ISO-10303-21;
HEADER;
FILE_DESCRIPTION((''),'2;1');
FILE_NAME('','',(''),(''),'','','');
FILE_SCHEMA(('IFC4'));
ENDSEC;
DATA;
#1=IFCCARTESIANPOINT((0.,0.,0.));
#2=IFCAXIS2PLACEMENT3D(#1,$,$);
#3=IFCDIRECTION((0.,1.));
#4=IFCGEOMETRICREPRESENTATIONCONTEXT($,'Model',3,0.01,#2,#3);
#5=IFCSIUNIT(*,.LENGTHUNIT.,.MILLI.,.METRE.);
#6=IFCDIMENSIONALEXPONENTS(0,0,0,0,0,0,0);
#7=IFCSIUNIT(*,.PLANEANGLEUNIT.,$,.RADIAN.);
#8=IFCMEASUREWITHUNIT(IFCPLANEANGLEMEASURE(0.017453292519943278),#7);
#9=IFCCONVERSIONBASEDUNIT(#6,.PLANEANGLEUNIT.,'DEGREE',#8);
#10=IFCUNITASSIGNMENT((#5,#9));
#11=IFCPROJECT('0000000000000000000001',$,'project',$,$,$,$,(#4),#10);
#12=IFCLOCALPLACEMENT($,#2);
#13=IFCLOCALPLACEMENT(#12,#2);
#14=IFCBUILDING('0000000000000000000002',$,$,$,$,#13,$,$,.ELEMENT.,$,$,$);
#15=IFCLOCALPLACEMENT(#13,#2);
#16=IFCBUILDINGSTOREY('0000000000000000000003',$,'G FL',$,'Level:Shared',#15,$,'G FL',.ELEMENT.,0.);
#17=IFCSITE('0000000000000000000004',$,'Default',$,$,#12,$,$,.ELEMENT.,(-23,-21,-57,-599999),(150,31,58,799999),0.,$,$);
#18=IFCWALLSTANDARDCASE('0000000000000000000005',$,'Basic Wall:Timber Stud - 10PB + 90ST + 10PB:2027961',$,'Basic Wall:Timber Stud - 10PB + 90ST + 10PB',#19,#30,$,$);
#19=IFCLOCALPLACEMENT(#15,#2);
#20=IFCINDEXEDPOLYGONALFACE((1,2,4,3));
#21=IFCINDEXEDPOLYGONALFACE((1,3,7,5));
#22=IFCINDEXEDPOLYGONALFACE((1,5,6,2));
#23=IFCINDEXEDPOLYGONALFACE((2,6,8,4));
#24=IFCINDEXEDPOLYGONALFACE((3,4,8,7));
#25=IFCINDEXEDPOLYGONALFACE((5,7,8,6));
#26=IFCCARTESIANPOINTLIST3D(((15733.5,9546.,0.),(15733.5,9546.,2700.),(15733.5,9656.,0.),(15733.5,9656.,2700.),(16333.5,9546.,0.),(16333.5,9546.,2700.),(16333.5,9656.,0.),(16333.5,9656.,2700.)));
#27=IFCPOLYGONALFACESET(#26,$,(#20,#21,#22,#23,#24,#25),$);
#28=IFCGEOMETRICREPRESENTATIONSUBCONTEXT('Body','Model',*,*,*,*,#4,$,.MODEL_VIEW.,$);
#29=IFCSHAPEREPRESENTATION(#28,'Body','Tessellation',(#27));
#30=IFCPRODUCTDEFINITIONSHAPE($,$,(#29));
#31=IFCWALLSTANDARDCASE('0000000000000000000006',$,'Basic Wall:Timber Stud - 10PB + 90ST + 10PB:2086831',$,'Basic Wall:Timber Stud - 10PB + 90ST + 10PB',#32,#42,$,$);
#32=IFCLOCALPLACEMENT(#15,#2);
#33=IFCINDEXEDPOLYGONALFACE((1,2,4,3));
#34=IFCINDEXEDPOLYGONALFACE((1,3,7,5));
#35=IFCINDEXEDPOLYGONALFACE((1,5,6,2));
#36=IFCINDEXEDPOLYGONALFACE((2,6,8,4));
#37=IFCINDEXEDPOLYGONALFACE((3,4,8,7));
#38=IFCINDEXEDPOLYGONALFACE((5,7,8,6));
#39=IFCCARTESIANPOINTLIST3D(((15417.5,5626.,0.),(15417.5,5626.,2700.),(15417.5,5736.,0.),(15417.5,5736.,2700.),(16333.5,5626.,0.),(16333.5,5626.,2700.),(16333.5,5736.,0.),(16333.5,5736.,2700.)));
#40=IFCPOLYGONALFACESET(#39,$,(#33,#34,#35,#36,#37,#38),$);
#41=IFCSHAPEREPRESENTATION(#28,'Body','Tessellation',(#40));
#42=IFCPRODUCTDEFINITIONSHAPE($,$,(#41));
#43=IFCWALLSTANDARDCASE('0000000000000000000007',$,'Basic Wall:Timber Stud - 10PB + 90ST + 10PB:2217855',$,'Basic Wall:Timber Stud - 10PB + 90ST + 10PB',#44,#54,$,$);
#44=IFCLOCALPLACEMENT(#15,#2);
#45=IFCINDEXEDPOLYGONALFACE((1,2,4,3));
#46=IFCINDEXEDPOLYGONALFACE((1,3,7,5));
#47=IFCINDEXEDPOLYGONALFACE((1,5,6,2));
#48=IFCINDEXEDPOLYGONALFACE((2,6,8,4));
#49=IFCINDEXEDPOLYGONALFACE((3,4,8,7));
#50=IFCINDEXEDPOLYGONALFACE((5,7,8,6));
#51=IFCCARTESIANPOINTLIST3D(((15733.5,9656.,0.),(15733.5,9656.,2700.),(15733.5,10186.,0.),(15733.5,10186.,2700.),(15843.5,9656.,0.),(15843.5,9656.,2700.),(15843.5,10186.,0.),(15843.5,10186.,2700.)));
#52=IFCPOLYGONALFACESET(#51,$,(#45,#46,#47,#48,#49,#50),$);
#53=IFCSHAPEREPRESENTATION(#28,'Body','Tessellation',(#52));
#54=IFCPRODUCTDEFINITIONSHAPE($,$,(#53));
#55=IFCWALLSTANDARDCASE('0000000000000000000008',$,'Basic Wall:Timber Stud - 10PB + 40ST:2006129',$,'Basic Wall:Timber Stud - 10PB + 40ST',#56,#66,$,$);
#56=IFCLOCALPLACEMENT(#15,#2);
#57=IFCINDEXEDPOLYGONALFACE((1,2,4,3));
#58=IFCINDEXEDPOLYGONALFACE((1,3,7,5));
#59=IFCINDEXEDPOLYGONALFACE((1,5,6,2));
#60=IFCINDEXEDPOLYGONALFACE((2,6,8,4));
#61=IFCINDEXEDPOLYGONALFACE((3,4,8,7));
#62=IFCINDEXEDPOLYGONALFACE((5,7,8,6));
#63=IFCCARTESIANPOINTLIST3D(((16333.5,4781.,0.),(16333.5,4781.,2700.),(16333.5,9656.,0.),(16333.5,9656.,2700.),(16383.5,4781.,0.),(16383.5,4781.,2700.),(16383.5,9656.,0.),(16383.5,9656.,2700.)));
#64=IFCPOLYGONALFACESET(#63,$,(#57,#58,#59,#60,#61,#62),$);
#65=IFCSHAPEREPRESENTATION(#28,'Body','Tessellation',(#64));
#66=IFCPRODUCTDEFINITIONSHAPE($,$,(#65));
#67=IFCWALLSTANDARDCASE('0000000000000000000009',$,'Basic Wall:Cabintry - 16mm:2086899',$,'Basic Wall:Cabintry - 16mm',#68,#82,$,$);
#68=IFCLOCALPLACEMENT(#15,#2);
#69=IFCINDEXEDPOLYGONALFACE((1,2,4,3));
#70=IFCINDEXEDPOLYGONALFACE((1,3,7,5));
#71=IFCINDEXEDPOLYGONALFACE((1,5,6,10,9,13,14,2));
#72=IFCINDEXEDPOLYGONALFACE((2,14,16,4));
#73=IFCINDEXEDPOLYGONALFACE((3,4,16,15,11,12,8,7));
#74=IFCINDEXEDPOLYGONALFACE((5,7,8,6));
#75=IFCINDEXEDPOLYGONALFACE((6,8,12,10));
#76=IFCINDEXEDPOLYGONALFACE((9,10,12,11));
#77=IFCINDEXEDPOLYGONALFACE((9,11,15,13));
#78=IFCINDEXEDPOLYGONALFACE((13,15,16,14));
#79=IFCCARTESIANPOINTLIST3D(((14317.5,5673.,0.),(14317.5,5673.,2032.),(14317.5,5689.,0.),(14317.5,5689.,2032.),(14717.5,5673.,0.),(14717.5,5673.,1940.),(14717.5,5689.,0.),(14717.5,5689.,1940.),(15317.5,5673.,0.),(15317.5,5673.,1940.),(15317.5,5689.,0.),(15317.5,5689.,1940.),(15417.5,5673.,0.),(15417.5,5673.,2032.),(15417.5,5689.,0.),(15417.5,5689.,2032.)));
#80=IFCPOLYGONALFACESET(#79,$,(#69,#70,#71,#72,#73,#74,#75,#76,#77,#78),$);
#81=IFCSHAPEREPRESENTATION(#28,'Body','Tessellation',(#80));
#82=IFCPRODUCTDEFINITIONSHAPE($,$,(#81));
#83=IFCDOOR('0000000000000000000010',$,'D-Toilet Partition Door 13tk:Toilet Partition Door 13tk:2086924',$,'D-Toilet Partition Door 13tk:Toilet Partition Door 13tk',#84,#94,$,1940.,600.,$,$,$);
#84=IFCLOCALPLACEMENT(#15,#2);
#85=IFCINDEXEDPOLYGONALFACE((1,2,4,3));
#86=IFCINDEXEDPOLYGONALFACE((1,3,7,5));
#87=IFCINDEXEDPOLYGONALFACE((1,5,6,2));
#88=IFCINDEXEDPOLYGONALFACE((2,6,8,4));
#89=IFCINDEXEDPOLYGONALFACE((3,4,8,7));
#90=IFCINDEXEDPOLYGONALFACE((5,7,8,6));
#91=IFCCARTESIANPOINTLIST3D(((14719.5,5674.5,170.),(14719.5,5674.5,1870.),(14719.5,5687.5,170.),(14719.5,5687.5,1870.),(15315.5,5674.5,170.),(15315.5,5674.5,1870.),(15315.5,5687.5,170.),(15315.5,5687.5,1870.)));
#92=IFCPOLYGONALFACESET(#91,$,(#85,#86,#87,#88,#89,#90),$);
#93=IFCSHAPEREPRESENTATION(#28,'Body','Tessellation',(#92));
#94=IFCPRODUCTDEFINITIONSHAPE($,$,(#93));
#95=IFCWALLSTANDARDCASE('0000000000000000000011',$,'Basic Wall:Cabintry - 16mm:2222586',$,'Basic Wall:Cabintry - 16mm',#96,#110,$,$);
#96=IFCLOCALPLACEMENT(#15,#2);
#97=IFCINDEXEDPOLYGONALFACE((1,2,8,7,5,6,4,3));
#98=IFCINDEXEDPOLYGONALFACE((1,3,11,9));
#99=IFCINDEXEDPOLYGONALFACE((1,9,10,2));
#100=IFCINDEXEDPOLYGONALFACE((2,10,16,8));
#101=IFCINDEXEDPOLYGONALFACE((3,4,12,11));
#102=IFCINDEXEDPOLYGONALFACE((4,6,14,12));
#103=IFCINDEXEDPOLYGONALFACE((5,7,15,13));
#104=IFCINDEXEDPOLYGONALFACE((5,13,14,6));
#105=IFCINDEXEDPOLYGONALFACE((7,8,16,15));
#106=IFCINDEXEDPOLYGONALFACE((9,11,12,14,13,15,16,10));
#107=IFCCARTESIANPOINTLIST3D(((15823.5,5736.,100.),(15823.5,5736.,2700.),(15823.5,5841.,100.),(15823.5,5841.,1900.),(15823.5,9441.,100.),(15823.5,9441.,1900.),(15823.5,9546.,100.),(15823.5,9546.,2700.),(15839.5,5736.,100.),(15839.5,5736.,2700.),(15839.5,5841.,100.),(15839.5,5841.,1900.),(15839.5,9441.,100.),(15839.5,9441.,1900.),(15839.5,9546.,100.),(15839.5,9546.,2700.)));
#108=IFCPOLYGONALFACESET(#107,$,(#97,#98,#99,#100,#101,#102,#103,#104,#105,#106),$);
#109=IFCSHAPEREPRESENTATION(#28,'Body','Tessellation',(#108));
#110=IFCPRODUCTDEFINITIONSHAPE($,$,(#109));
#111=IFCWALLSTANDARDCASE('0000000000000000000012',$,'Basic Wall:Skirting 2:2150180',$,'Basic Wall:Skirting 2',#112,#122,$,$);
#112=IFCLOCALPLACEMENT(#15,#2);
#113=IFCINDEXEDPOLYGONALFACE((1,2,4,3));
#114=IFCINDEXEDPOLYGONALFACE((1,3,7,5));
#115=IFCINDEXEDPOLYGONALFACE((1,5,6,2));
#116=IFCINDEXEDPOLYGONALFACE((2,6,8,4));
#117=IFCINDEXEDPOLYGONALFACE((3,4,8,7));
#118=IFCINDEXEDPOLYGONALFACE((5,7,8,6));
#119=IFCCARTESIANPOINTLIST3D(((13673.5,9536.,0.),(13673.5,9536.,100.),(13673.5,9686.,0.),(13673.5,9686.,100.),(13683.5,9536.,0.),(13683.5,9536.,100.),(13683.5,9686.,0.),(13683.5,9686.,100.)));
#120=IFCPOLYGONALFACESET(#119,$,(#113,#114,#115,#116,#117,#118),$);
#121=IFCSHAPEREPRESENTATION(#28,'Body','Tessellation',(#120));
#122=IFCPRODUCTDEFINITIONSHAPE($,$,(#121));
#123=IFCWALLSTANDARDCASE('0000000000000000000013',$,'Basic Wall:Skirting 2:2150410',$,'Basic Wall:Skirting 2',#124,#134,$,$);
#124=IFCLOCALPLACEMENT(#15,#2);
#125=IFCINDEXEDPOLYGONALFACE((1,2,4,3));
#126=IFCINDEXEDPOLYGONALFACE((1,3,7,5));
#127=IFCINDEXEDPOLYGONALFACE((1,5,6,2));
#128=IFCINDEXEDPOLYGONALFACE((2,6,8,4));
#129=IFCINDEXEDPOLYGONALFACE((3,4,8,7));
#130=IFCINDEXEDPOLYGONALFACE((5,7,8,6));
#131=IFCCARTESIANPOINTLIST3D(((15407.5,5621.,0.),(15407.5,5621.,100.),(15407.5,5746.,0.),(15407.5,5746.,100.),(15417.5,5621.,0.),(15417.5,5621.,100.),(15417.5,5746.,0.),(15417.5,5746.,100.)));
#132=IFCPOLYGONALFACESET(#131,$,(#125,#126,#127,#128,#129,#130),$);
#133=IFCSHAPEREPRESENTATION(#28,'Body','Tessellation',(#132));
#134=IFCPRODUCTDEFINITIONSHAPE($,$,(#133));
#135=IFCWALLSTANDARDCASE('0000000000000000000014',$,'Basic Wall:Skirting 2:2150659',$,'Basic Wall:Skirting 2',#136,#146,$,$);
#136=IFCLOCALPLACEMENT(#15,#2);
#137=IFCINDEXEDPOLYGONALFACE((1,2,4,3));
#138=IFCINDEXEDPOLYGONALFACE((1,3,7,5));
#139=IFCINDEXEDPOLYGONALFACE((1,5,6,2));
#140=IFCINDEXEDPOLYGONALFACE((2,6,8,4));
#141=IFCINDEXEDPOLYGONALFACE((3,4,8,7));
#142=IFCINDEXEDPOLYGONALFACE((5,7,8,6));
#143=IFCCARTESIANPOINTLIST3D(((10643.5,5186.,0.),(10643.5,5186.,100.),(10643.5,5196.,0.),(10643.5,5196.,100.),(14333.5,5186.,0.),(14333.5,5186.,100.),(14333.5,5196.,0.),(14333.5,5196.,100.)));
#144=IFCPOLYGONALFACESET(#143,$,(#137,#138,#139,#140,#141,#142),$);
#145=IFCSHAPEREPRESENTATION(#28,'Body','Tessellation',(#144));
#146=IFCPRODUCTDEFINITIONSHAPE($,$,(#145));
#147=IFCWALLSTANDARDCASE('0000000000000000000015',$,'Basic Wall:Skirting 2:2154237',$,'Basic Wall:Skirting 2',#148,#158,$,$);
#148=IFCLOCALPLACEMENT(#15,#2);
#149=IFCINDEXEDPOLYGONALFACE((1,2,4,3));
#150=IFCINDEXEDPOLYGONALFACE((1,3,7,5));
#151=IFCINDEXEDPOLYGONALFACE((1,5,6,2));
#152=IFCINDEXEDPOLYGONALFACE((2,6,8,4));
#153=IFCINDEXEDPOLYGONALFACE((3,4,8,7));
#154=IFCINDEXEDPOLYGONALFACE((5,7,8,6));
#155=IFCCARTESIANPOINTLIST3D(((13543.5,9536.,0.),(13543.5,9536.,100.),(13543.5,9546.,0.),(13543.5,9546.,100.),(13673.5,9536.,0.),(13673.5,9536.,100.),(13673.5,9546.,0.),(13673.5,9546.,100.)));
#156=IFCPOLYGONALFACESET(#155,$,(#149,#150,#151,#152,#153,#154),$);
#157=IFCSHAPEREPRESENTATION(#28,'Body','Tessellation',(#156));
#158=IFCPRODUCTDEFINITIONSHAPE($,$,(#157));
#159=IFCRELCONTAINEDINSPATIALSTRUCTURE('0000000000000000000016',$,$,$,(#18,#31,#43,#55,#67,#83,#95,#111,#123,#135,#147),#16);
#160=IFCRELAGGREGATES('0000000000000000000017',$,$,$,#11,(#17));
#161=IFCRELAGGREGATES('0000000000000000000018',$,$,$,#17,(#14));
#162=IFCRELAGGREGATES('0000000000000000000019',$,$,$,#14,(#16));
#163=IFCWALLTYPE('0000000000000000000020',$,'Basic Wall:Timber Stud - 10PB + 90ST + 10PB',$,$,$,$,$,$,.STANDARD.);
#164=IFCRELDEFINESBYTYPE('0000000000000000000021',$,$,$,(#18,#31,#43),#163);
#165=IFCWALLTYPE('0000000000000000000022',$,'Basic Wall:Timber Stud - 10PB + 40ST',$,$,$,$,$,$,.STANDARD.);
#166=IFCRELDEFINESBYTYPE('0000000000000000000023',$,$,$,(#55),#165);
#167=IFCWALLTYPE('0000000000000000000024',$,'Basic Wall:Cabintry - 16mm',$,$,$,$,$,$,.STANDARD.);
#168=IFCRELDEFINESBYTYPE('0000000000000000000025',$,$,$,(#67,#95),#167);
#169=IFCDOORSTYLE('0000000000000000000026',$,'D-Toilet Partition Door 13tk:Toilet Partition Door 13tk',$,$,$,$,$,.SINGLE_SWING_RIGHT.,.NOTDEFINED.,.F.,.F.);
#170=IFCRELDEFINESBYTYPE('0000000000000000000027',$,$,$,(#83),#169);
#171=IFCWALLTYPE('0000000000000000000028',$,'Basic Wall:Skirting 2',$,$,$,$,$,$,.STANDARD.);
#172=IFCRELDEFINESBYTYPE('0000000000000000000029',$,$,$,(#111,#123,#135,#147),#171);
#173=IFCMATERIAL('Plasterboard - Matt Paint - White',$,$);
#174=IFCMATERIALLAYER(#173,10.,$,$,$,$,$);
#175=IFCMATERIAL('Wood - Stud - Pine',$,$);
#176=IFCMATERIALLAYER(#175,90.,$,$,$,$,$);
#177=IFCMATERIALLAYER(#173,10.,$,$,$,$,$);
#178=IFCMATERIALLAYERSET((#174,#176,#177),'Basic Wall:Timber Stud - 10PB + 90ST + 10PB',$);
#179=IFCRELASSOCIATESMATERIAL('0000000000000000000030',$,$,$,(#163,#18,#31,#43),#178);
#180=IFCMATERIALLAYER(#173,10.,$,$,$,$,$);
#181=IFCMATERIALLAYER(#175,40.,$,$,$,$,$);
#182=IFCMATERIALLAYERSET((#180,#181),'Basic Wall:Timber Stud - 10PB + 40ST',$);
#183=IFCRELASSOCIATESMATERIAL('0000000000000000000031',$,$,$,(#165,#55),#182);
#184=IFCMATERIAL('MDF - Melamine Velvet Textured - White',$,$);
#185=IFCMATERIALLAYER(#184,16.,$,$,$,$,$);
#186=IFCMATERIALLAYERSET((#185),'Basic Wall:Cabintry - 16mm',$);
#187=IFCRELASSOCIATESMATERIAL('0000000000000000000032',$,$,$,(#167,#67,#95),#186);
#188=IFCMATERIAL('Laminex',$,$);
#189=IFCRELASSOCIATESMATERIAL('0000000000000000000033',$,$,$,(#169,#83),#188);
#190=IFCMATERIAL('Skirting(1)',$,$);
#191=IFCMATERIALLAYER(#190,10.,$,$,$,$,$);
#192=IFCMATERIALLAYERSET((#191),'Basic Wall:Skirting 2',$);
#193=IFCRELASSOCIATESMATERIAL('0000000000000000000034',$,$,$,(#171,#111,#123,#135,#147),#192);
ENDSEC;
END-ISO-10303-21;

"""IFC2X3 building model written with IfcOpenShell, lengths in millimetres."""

from ifc_helpers import new_model, entity, si_unit, converted_unit, direction, frame, frame_2d, origin, origin_2d_with_axis, place, context, subcontext, project, spatial, rectangle, extrude, source, transform, mapped, material, layer, layer_set, layer_usage, type_object, type_shapes, element, fill, save


model = new_model("IFC2X3")

# Units and contexts
model_context = context("Model", 3, precision=0.01, world=origin(), true_north=direction((0.0, 1.0)))
body_context = subcontext(model_context, "Body", "Model", "MODEL_VIEW")
ifc_project = project(units=[si_unit("LENGTHUNIT", "METRE", prefix="MILLI"), converted_unit("PLANEANGLEUNIT", "DEGREE", entity("IfcPlaneAngleMeasure", 0.017453292519943278), si_unit("PLANEANGLEUNIT", "RADIAN"), dimensions=[0, 0, 0, 0, 0, 0, 0])], contexts=[model_context])

# Site, building, storey
site_placement = place(None, origin())
site = spatial("IfcSite", under=ifc_project, at=site_placement, Name="Default", CompositionType="ELEMENT", RefLatitude=(-23, -21, -57, -599999), RefLongitude=(150, 31, 58, 799999), RefElevation=0.0)
building_placement = place(site_placement, origin())
building = spatial("IfcBuilding", under=site, at=building_placement, CompositionType="ELEMENT")
storey_placement = place(building_placement, origin())
storey = spatial("IfcBuildingStorey", under=building, at=storey_placement, Name="G FL", ObjectType="Level:Shared", LongName="G FL", CompositionType="ELEMENT", Elevation=0.0)

# Walls
ifc_material_1 = material(Name="Plasterboard - Matt Paint - White")
ifc_layer_1 = layer(ifc_material_1, 10.0)
ifc_material_2 = material(Name="Wood - Stud - Pine")
ifc_layer_2 = layer(ifc_material_2, 90.0)
ifc_layer_3 = layer(ifc_material_1, 10.0)
ifc_layer_set_1 = layer_set([ifc_layer_1, ifc_layer_2, ifc_layer_3], Name="Basic Wall:Timber Stud - 10PB + 90ST + 10PB")
ifc_layer_usage_1 = layer_usage(ifc_layer_set_1, "AXIS2", "NEGATIVE", 55.0)
wall_type_1 = type_object("IfcWallType", Name="Basic Wall:Timber Stud - 10PB + 90ST + 10PB", PredefinedType="STANDARD", material=ifc_layer_set_1)
wall_1_placement = place(storey_placement, frame((15733.5, 9601.0, 0.0)))
element("IfcWallStandardCase", 1, at=wall_1_placement, inside=storey, type_object=wall_type_1, material=ifc_layer_usage_1, Name="Basic Wall:Timber Stud - 10PB + 90ST + 10PB:2027961", ObjectType="Basic Wall:Timber Stud - 10PB + 90ST + 10PB", context=body_context, shape_type="SweptSolid", body=[
    extrude(rectangle(XDim=600.0, YDim=110.0, at=frame_2d((300.0, 0.0), x_axis=(-1.0, 0.0))), origin(), (0.0, 0.0, 1.0), 2700.0),
])
ifc_layer_usage_2 = layer_usage(ifc_layer_set_1, "AXIS2", "NEGATIVE", 55.0)
wall_2_placement = place(storey_placement, frame((15417.5, 5681.0, 0.0)))
element("IfcWallStandardCase", 2, at=wall_2_placement, inside=storey, type_object=wall_type_1, material=ifc_layer_usage_2, Name="Basic Wall:Timber Stud - 10PB + 90ST + 10PB:2086831", ObjectType="Basic Wall:Timber Stud - 10PB + 90ST + 10PB", context=body_context, shape_type="SweptSolid", body=[
    extrude(rectangle(XDim=916.0, YDim=110.0, at=frame_2d((458.0, 0.0), x_axis=(-1.0, 0.0))), origin(), (0.0, 0.0, 1.0), 2700.0),
])
ifc_layer_usage_3 = layer_usage(ifc_layer_set_1, "AXIS2", "POSITIVE", -55.0)
wall_3_placement = place(storey_placement, frame((15788.5, 9656.0, 0.0), z_axis=(0.0, 0.0, 1.0), x_axis=(0.0, 1.0, 0.0)))
element("IfcWallStandardCase", 3, at=wall_3_placement, inside=storey, type_object=wall_type_1, material=ifc_layer_usage_3, Name="Basic Wall:Timber Stud - 10PB + 90ST + 10PB:2217855", ObjectType="Basic Wall:Timber Stud - 10PB + 90ST + 10PB", context=body_context, shape_type="SweptSolid", body=[
    extrude(rectangle(XDim=530.0, YDim=110.0, at=frame_2d((265.0, 0.0), x_axis=(-1.0, 0.0))), origin(), (0.0, 0.0, 1.0), 2700.0),
])
ifc_layer_4 = layer(ifc_material_1, 10.0)
ifc_layer_5 = layer(ifc_material_2, 40.0)
ifc_layer_set_2 = layer_set([ifc_layer_4, ifc_layer_5], Name="Basic Wall:Timber Stud - 10PB + 40ST")
ifc_layer_usage_4 = layer_usage(ifc_layer_set_2, "AXIS2", "POSITIVE", -25.0)
wall_type_2 = type_object("IfcWallType", Name="Basic Wall:Timber Stud - 10PB + 40ST", PredefinedType="STANDARD", material=ifc_layer_set_2)
wall_4_placement = place(storey_placement, frame((16358.5, 9656.0, 0.0), z_axis=(0.0, 0.0, 1.0), x_axis=(0.0, -1.0, 0.0)))
element("IfcWallStandardCase", 4, at=wall_4_placement, inside=storey, type_object=wall_type_2, material=ifc_layer_usage_4, Name="Basic Wall:Timber Stud - 10PB + 40ST:2006129", ObjectType="Basic Wall:Timber Stud - 10PB + 40ST", context=body_context, shape_type="SweptSolid", body=[
    extrude(rectangle(XDim=4875.0, YDim=50.0, at=frame_2d((2437.5, 0.0), x_axis=(-1.0, 0.0))), origin(), (0.0, 0.0, 1.0), 2700.0),
])

# Wall, opening, door
ifc_material_3 = material(Name="MDF - Melamine Velvet Textured - White")
ifc_layer_6 = layer(ifc_material_3, 16.0)
ifc_layer_set_3 = layer_set([ifc_layer_6], Name="Basic Wall:Cabintry - 16mm")
ifc_layer_usage_5 = layer_usage(ifc_layer_set_3, "AXIS2", "NEGATIVE", 8.0)
wall_type_3 = type_object("IfcWallType", Name="Basic Wall:Cabintry - 16mm", PredefinedType="STANDARD", material=ifc_layer_set_3)
wall_5_placement = place(storey_placement, frame((14317.5, 5681.0, 0.0)))
wall_5 = element("IfcWallStandardCase", 5, at=wall_5_placement, inside=storey, type_object=wall_type_3, material=ifc_layer_usage_5, Name="Basic Wall:Cabintry - 16mm:2086899", ObjectType="Basic Wall:Cabintry - 16mm", context=body_context, shape_type="SweptSolid", body=[
    extrude(rectangle(XDim=1100.0, YDim=16.0, at=frame_2d((550.0, 0.0), x_axis=(-1.0, 0.0))), origin(), (0.0, 0.0, 1.0), 2032.0),
])
opening_1_placement = place(wall_5_placement, frame((1000.0, 8.0, 0.0)))
opening_1 = element("IfcOpeningElement", 6, at=opening_1_placement, cuts=wall_5, ObjectType="Opening", context=body_context, shape_type="SweptSolid", body=[
    extrude(rectangle(XDim=1940.0, YDim=600.0, at=frame_2d((970.0, 300.0), x_axis=(1.0, 0.0))), frame((0.0, 0.0, 0.0), z_axis=(0.0, -1.0, 0.0), x_axis=(0.0, 0.0, 1.0)), (0.0, 0.0, 1.0), 16.0),
])
ifc_material_4 = material(Name="Laminex")
door_style = type_object("IfcDoorStyle", Name="D-Toilet Partition Door 13tk:Toilet Partition Door 13tk", ConstructionType="NOTDEFINED", OperationType="SINGLE_SWING_RIGHT", ParameterTakesPrecedence=False, Sizeable=False, material=ifc_material_4)
shared_shape_1 = source(origin(), body_context, "Body", "SweptSolid", [
    extrude(rectangle(XDim=596.0, YDim=13.0, at=frame_2d((0.0, 0.0), x_axis=(1.0, 0.0))), frame((300.0, 8.0, 170.0)), (0.0, 0.0, 1.0), 1700.0),
])
type_shapes(door_style, [shared_shape_1])
door_placement = place(opening_1_placement, frame((0.0, 0.0, 0.0), z_axis=(0.0, 0.0, 1.0), x_axis=(-1.0, 0.0, 0.0)))
door = element("IfcDoor", 7, at=door_placement, inside=storey, type_object=door_style, material=ifc_material_4, Name="D-Toilet Partition Door 13tk:Toilet Partition Door 13tk:2086924", ObjectType="D-Toilet Partition Door 13tk:Toilet Partition Door 13tk", OverallHeight=1940.0, OverallWidth=600.0, context=body_context, shape_type="MappedRepresentation", body=[
    mapped(shared_shape_1, transform((0.0, 0.0, 0.0), scale=1.0)),
])
fill(opening_1, door)

# Wall, opening
ifc_layer_usage_6 = layer_usage(ifc_layer_set_3, "AXIS2", "NEGATIVE", 8.0)
wall_6_placement = place(storey_placement, frame((15831.5, 5736.0, 100.0), z_axis=(0.0, 0.0, 1.0), x_axis=(0.0, 1.0, 0.0)))
wall_6 = element("IfcWallStandardCase", 8, at=wall_6_placement, inside=storey, type_object=wall_type_3, material=ifc_layer_usage_6, Name="Basic Wall:Cabintry - 16mm:2222586", ObjectType="Basic Wall:Cabintry - 16mm", context=body_context, shape_type="SweptSolid", body=[
    extrude(rectangle(XDim=3810.0, YDim=16.0, at=frame_2d((1905.0, 0.0), x_axis=(-1.0, 0.0))), origin(), (0.0, 0.0, 1.0), 2600.0),
])
opening_2_placement = place(wall_6_placement, origin())
element("IfcOpeningElement", 9, at=opening_2_placement, cuts=wall_6, ObjectType="Opening", context=body_context, shape_type="SweptSolid", body=[
    extrude(rectangle(XDim=1800.0, YDim=3600.0, at=frame_2d((0.0, 0.0), x_axis=(0.0, 1.0))), frame((1905.0, 8.0, 900.0), z_axis=(0.0, -1.0, 0.0), x_axis=(1.0, 0.0, 0.0)), (0.0, 0.0, 1.0), 16.0),
])

# Walls
ifc_material_5 = material(Name="Skirting(1)")
ifc_layer_7 = layer(ifc_material_5, 10.0)
ifc_layer_set_4 = layer_set([ifc_layer_7], Name="Basic Wall:Skirting 2")
ifc_layer_usage_7 = layer_usage(ifc_layer_set_4, "AXIS2", "NEGATIVE", 5.0)
wall_type_4 = type_object("IfcWallType", Name="Basic Wall:Skirting 2", PredefinedType="STANDARD", material=ifc_layer_set_4)
wall_7_placement = place(storey_placement, frame((13678.5, 9536.0, 0.0), z_axis=(0.0, 0.0, 1.0), x_axis=(0.0, 1.0, 0.0)))
element("IfcWallStandardCase", 10, at=wall_7_placement, inside=storey, type_object=wall_type_4, material=ifc_layer_usage_7, Name="Basic Wall:Skirting 2:2150180", ObjectType="Basic Wall:Skirting 2", context=body_context, shape_type="SweptSolid", body=[
    extrude(rectangle(XDim=150.0, YDim=10.0, at=frame_2d((75.0, 0.0), x_axis=(-1.0, 0.0))), origin(), (0.0, 0.0, 1.0), 100.0),
])
ifc_layer_usage_8 = layer_usage(ifc_layer_set_4, "AXIS2", "NEGATIVE", 5.0)
wall_8_placement = place(storey_placement, frame((15412.5, 5746.0, 0.0), z_axis=(0.0, 0.0, 1.0), x_axis=(0.0, -1.0, 0.0)))
element("IfcWallStandardCase", 11, at=wall_8_placement, inside=storey, type_object=wall_type_4, material=ifc_layer_usage_8, Name="Basic Wall:Skirting 2:2150410", ObjectType="Basic Wall:Skirting 2", context=body_context, shape_type="SweptSolid", body=[
    extrude(rectangle(XDim=125.0, YDim=10.0, at=frame_2d((62.5, 0.0), x_axis=(-1.0, 0.0))), origin(), (0.0, 0.0, 1.0), 100.0),
])
ifc_layer_usage_9 = layer_usage(ifc_layer_set_4, "AXIS2", "NEGATIVE", 5.0)
wall_9_placement = place(storey_placement, frame((14333.5, 5191.0, 0.0), z_axis=(0.0, 0.0, 1.0), x_axis=(-1.0, 0.0, 0.0)))
element("IfcWallStandardCase", 12, at=wall_9_placement, inside=storey, type_object=wall_type_4, material=ifc_layer_usage_9, Name="Basic Wall:Skirting 2:2150659", ObjectType="Basic Wall:Skirting 2", context=body_context, shape_type="SweptSolid", body=[
    extrude(rectangle(XDim=3690.0, YDim=10.0, at=frame_2d((1845.0, 0.0), x_axis=(-1.0, 0.0))), origin(), (0.0, 0.0, 1.0), 100.0),
])
ifc_layer_usage_10 = layer_usage(ifc_layer_set_4, "AXIS2", "POSITIVE", -5.0)
wall_10_placement = place(storey_placement, frame((13673.5, 9541.0, 0.0), z_axis=(0.0, 0.0, 1.0), x_axis=(-1.0, 0.0, 0.0)))
element("IfcWallStandardCase", 13, at=wall_10_placement, inside=storey, type_object=wall_type_4, material=ifc_layer_usage_10, Name="Basic Wall:Skirting 2:2154237", ObjectType="Basic Wall:Skirting 2", context=body_context, shape_type="SweptSolid", body=[
    extrude(rectangle(XDim=130.0, YDim=10.0, at=origin_2d_with_axis()), frame((65.0, 0.0, 0.0)), (0.0, 0.0, 1.0), 100.0),
])

save(model, "model.ifc")
